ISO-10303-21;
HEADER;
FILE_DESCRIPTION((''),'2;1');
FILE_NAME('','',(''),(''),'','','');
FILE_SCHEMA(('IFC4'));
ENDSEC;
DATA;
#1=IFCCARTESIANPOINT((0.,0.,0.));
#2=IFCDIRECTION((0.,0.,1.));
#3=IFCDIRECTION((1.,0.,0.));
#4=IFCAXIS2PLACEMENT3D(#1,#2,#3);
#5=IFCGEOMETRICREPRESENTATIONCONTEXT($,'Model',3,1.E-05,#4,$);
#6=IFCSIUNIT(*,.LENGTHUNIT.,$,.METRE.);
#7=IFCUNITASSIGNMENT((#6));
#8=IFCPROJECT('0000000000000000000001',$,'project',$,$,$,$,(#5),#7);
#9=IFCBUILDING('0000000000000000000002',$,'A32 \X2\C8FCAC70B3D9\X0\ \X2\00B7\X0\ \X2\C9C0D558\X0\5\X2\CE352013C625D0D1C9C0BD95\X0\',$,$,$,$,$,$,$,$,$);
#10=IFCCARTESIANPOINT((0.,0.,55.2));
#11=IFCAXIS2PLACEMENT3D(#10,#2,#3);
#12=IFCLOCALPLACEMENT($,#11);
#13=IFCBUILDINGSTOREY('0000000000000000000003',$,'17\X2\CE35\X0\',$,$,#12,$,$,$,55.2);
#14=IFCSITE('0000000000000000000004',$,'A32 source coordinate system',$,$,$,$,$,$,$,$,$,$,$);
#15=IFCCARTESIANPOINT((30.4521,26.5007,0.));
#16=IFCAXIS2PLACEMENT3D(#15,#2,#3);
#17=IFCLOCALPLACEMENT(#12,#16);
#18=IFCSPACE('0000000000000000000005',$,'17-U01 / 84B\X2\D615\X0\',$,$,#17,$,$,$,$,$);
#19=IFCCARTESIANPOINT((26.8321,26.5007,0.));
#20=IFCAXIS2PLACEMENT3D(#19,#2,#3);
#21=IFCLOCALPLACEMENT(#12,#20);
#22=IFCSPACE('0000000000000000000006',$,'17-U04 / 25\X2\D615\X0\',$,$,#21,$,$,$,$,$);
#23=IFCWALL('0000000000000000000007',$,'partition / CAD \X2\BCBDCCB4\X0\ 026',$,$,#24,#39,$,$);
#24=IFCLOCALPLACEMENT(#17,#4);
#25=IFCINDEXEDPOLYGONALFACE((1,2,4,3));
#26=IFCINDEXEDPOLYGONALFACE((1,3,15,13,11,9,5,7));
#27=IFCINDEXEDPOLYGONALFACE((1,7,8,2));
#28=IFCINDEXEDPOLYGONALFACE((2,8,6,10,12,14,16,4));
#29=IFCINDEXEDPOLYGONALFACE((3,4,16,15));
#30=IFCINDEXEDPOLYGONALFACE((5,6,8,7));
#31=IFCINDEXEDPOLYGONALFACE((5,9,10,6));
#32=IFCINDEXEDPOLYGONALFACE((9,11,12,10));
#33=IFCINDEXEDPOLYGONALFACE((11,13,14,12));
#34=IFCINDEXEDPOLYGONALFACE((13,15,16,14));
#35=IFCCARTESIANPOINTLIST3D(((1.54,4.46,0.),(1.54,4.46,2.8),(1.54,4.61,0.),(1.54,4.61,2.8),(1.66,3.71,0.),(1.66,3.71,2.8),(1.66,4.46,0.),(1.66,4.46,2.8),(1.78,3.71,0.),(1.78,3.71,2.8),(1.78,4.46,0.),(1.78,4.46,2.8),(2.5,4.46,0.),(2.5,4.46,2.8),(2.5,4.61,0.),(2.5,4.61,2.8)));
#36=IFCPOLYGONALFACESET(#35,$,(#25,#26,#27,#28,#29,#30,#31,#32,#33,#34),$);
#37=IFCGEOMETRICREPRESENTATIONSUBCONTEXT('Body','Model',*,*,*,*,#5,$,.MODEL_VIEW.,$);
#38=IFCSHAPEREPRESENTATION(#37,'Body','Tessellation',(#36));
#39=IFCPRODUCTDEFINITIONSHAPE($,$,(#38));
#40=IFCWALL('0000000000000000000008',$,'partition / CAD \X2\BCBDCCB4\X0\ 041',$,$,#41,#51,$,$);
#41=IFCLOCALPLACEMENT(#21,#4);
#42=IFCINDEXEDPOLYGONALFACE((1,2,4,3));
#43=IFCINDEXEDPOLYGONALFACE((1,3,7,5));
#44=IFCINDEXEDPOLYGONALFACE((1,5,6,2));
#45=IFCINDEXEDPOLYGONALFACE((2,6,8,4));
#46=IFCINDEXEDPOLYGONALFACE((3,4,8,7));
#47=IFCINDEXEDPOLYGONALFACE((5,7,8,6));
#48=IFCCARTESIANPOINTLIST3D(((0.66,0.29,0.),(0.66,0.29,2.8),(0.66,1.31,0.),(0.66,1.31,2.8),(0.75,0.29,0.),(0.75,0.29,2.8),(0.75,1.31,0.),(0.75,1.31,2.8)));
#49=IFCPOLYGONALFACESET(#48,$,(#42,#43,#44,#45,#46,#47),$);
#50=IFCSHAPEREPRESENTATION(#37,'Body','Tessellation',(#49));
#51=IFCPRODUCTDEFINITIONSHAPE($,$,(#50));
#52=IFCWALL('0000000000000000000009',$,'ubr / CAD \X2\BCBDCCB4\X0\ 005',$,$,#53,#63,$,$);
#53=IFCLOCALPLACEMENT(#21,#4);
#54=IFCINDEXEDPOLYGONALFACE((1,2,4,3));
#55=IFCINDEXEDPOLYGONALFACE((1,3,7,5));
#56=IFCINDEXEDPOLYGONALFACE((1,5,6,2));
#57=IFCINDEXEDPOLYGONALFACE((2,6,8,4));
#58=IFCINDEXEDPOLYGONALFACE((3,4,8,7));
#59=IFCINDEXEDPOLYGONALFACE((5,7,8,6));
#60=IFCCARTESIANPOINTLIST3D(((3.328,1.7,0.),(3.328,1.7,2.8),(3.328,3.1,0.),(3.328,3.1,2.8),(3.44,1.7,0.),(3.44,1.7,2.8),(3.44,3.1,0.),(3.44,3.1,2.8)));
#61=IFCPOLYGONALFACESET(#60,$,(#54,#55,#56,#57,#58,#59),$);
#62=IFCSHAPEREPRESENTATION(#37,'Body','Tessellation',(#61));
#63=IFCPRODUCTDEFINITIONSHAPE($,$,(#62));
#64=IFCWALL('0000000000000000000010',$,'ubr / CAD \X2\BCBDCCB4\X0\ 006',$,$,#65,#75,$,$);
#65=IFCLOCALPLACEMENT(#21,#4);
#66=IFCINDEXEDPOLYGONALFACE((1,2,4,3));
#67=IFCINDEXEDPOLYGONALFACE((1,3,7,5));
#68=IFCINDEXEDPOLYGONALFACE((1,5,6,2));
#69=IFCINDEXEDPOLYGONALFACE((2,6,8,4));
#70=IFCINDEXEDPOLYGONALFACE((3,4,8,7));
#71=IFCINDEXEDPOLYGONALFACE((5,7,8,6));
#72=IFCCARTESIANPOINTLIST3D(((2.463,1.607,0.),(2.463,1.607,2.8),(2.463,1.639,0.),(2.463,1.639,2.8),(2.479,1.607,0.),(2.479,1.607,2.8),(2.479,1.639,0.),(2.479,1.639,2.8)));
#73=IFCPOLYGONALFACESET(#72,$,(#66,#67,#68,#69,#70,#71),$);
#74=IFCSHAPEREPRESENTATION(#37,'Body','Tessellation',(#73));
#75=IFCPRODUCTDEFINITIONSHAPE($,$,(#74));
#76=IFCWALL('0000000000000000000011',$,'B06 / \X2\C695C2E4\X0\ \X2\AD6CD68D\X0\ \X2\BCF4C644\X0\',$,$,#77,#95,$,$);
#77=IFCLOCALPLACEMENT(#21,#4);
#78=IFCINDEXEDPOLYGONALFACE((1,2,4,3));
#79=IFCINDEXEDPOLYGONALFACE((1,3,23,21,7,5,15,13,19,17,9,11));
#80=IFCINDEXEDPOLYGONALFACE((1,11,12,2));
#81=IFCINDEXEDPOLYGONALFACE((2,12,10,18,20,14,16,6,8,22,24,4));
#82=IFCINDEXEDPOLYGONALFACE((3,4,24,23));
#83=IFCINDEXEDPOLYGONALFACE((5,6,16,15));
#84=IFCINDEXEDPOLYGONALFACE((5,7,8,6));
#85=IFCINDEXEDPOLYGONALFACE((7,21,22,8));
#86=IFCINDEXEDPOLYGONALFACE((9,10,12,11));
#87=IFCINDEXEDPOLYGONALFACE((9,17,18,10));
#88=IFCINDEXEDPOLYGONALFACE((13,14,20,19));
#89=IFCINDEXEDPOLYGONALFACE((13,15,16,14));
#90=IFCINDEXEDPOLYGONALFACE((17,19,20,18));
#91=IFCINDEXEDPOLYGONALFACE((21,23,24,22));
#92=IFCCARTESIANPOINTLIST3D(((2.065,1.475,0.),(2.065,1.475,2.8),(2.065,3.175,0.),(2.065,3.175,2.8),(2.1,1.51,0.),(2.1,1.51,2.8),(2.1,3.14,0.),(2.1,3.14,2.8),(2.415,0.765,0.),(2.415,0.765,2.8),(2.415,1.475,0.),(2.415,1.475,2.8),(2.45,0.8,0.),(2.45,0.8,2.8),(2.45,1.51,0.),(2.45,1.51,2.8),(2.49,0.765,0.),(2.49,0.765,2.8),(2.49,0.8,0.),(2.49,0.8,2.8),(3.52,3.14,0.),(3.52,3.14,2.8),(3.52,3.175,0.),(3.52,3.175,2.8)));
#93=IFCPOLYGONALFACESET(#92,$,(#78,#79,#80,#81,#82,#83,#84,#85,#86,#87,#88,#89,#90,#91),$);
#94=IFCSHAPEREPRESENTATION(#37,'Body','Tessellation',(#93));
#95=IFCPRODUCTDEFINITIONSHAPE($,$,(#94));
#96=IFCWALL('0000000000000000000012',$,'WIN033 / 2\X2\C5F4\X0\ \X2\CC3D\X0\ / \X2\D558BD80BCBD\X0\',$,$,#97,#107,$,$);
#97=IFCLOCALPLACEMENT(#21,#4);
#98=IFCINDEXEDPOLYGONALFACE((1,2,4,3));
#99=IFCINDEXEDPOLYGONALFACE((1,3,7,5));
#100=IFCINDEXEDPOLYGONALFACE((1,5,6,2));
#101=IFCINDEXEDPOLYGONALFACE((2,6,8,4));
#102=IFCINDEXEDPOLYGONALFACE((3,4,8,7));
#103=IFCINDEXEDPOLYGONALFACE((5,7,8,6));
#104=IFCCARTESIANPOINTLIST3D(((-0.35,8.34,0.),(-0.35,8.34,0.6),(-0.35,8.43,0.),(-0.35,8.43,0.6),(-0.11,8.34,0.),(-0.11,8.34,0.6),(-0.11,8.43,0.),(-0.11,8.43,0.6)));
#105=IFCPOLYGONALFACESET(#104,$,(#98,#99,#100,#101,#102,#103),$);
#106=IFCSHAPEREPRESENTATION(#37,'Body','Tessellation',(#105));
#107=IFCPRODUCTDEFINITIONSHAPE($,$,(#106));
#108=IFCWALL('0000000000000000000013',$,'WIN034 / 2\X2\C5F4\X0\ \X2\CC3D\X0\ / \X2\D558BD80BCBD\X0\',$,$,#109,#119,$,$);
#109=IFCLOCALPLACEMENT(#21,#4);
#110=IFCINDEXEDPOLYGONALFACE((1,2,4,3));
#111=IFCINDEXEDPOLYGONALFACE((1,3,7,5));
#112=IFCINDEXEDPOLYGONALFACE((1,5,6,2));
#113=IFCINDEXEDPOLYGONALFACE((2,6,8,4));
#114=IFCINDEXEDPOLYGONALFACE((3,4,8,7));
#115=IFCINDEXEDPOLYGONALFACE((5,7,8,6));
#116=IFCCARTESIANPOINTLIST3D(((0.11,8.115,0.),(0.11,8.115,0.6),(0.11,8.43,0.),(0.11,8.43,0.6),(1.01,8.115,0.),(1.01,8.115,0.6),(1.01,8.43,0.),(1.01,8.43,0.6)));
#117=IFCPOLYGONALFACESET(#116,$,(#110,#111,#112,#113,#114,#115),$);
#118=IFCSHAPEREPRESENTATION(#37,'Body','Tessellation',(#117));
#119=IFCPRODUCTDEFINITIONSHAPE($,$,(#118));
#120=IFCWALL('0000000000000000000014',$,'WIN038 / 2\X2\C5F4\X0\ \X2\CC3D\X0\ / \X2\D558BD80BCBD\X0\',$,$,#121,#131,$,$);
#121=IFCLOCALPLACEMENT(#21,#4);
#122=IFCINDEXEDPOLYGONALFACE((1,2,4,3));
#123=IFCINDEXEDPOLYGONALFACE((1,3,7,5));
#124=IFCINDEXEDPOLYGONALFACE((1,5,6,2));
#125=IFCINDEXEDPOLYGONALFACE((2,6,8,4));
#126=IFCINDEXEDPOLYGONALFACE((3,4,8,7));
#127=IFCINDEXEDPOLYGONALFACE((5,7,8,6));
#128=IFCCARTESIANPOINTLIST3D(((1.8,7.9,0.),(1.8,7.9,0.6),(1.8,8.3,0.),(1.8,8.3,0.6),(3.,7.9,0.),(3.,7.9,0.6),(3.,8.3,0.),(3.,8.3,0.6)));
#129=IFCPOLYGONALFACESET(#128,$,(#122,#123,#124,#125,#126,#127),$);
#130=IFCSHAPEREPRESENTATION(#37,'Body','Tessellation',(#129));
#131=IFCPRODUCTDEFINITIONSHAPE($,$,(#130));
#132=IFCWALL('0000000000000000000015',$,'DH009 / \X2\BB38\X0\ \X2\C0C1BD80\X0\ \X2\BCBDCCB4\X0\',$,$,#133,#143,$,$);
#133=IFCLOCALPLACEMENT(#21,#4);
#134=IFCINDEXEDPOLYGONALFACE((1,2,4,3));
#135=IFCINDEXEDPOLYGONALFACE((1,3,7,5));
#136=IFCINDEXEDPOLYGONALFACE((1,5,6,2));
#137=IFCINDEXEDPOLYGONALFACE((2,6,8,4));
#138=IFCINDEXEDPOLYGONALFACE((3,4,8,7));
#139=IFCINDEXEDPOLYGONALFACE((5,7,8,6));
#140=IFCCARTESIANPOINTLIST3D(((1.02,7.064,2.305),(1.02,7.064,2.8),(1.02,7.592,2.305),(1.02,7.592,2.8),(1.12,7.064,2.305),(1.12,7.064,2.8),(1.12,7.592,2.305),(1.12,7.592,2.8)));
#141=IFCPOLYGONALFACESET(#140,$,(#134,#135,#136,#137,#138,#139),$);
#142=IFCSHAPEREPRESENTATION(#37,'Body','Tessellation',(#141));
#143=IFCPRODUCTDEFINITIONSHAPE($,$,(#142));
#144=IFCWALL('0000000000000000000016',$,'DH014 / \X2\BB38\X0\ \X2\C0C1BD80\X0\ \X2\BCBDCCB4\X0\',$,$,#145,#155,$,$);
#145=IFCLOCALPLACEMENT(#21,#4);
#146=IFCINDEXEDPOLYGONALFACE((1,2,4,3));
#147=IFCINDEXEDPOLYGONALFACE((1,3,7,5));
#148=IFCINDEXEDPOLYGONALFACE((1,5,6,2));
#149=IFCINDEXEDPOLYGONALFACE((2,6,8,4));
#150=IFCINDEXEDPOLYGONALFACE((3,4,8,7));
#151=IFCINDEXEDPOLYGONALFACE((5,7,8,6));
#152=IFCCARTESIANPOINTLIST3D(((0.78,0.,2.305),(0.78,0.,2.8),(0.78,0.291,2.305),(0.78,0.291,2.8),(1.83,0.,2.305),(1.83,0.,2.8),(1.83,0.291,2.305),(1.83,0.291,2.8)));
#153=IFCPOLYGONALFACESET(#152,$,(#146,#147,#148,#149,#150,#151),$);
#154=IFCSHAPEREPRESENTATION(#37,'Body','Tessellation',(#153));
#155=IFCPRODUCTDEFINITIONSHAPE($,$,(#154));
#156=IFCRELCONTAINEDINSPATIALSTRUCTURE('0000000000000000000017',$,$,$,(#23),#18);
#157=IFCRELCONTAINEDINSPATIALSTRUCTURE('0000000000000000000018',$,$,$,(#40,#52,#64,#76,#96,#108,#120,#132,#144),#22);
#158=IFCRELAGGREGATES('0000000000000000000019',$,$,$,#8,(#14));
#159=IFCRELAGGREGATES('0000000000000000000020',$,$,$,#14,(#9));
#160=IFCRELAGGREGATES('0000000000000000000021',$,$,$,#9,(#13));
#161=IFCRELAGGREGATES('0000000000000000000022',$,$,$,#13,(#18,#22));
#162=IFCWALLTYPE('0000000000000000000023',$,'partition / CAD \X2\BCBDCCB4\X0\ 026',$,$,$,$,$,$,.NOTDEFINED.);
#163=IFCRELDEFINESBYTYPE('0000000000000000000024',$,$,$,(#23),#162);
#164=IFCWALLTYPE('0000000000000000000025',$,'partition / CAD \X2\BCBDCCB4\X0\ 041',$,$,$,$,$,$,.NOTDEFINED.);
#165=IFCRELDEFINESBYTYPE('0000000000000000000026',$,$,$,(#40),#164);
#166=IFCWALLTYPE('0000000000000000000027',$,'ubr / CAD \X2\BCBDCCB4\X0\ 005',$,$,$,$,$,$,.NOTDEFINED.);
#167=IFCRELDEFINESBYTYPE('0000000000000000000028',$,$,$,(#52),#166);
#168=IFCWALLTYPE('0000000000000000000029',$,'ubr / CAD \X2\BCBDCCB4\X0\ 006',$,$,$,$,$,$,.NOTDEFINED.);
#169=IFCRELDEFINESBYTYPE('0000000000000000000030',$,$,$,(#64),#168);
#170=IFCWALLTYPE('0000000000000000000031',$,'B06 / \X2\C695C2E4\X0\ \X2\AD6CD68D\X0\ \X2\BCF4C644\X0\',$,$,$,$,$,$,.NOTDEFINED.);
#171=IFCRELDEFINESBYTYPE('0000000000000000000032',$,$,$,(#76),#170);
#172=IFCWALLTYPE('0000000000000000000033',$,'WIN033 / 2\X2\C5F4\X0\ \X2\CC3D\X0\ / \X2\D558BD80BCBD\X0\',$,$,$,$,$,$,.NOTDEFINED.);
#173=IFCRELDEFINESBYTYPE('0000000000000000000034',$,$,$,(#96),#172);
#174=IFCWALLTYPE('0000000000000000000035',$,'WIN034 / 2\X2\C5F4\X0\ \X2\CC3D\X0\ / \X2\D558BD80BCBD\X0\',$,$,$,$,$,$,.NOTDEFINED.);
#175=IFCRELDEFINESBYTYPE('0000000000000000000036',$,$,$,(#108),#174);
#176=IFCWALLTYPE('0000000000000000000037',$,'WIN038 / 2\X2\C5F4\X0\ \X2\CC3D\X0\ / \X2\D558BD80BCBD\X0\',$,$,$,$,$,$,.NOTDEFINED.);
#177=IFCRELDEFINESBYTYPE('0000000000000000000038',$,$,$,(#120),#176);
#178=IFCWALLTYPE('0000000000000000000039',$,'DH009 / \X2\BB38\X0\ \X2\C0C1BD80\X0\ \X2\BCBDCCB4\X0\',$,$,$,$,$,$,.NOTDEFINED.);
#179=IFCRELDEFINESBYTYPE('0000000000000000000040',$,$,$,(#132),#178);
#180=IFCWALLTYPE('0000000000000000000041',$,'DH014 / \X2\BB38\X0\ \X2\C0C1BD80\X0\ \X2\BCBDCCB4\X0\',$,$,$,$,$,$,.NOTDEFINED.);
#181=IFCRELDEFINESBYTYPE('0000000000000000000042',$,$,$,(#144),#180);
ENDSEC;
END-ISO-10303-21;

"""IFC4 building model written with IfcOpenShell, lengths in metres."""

from ifc_helpers import new_model, si_unit, frame, origin, origin_with_axes, place, context, subcontext, project, spatial, polyline, outline, extrude, source, transform, mapped, type_object, type_shapes, element, save


model = new_model("IFC4")

# Units and contexts
model_context = context("Model", 3, precision=1e-05, world=origin_with_axes())
body_context = subcontext(model_context, "Body", "Model", "MODEL_VIEW")
ifc_project = project(units=[si_unit("LENGTHUNIT", "METRE")], contexts=[model_context])

# Site, building, storey, space
site = spatial("IfcSite", under=ifc_project, Name="A32 source coordinate system")
building = spatial("IfcBuilding", under=site, Name="A32 주거동 · 지하5층–옥탑지붕")
storey_placement = place(None, frame((0.0, 0.0, 55.2), z_axis=(0.0, 0.0, 1.0), x_axis=(1.0, 0.0, 0.0)))
storey = spatial("IfcBuildingStorey", under=building, at=storey_placement, Name="17층", Elevation=55.2)
space_1_placement = place(storey_placement, frame((30.4521, 26.5007, 0.0), z_axis=(0.0, 0.0, 1.0), x_axis=(1.0, 0.0, 0.0)))
space_1 = spatial("IfcSpace", under=storey, at=space_1_placement, Name="17-U01 / 84B형")

# Wall
wall_type_1 = type_object("IfcWallType", Name="partition / CAD 벽체 026", PredefinedType="NOTDEFINED")
shared_shape_1 = source(origin(), body_context, "Body", "SweptSolid", [
    extrude(outline(polyline([(1.54, 4.46), (1.54, 4.61), (2.5, 4.61), (2.5, 4.46), (1.78, 4.46), (1.78, 3.71), (1.66, 3.71), (1.66, 4.46), (1.54, 4.46)])), origin(), (0.0, 0.0, 1.0), 2.8),
])
type_shapes(wall_type_1, [shared_shape_1])
wall_1_placement = place(space_1_placement, origin_with_axes())
element("IfcWall", 1, at=wall_1_placement, inside=space_1, type_object=wall_type_1, Name="partition / CAD 벽체 026", context=body_context, shape_type="MappedRepresentation", body=[
    mapped(shared_shape_1, transform((0.0, 0.0, 0.0), scale=1.0)),
])

# Shared definitions
space_2_placement = place(storey_placement, frame((26.8321, 26.5007, 0.0), z_axis=(0.0, 0.0, 1.0), x_axis=(1.0, 0.0, 0.0)))
space_2 = spatial("IfcSpace", under=storey, at=space_2_placement, Name="17-U04 / 25형")

# Walls
wall_type_2 = type_object("IfcWallType", Name="partition / CAD 벽체 041", PredefinedType="NOTDEFINED")
shared_shape_2 = source(origin(), body_context, "Body", "SweptSolid", [
    extrude(outline(polyline([(0.75, 1.31), (0.75, 0.29), (0.66, 0.29), (0.66, 1.31), (0.75, 1.31)])), origin(), (0.0, 0.0, 1.0), 2.8),
])
type_shapes(wall_type_2, [shared_shape_2])
wall_2_placement = place(space_2_placement, origin_with_axes())
element("IfcWall", 2, at=wall_2_placement, inside=space_2, type_object=wall_type_2, Name="partition / CAD 벽체 041", context=body_context, shape_type="MappedRepresentation", body=[
    mapped(shared_shape_2, transform((0.0, 0.0, 0.0), scale=1.0)),
])
wall_type_3 = type_object("IfcWallType", Name="ubr / CAD 벽체 005", PredefinedType="NOTDEFINED")
shared_shape_3 = source(origin(), body_context, "Body", "SweptSolid", [
    extrude(outline(polyline([(3.44, 3.1), (3.44, 1.7), (3.328, 1.7), (3.328, 3.1), (3.44, 3.1)])), origin(), (0.0, 0.0, 1.0), 2.8),
])
type_shapes(wall_type_3, [shared_shape_3])
wall_3_placement = place(space_2_placement, origin_with_axes())
element("IfcWall", 3, at=wall_3_placement, inside=space_2, type_object=wall_type_3, Name="ubr / CAD 벽체 005", context=body_context, shape_type="MappedRepresentation", body=[
    mapped(shared_shape_3, transform((0.0, 0.0, 0.0), scale=1.0)),
])
wall_type_4 = type_object("IfcWallType", Name="ubr / CAD 벽체 006", PredefinedType="NOTDEFINED")
shared_shape_4 = source(origin(), body_context, "Body", "SweptSolid", [
    extrude(outline(polyline([(2.463, 1.639), (2.479, 1.639), (2.479, 1.607), (2.463, 1.607), (2.463, 1.639)])), origin(), (0.0, 0.0, 1.0), 2.8),
])
type_shapes(wall_type_4, [shared_shape_4])
wall_4_placement = place(space_2_placement, origin_with_axes())
element("IfcWall", 4, at=wall_4_placement, inside=space_2, type_object=wall_type_4, Name="ubr / CAD 벽체 006", context=body_context, shape_type="MappedRepresentation", body=[
    mapped(shared_shape_4, transform((0.0, 0.0, 0.0), scale=1.0)),
])
wall_type_5 = type_object("IfcWallType", Name="B06 / 욕실 구획 보완", PredefinedType="NOTDEFINED")
shared_shape_5 = source(origin(), body_context, "Body", "SweptSolid", [
    extrude(outline(polyline([(3.52, 3.14), (2.1, 3.14), (2.1, 1.51), (2.45, 1.51), (2.45, 0.8), (2.49, 0.8), (2.49, 0.765), (2.415, 0.765), (2.415, 1.475), (2.065, 1.475), (2.065, 3.175), (3.52, 3.175), (3.52, 3.14)])), origin(), (0.0, 0.0, 1.0), 2.8),
])
type_shapes(wall_type_5, [shared_shape_5])
wall_5_placement = place(space_2_placement, origin_with_axes())
element("IfcWall", 5, at=wall_5_placement, inside=space_2, type_object=wall_type_5, Name="B06 / 욕실 구획 보완", context=body_context, shape_type="MappedRepresentation", body=[
    mapped(shared_shape_5, transform((0.0, 0.0, 0.0), scale=1.0)),
])
wall_type_6 = type_object("IfcWallType", Name="WIN033 / 2열 창 / 하부벽", PredefinedType="NOTDEFINED")
shared_shape_6 = source(origin(), body_context, "Body", "SweptSolid", [
    extrude(outline(polyline([(-0.11, 8.43), (-0.11, 8.34), (-0.35, 8.34), (-0.35, 8.43), (-0.11, 8.43)])), origin(), (0.0, 0.0, 1.0), 0.6),
])
type_shapes(wall_type_6, [shared_shape_6])
wall_6_placement = place(space_2_placement, origin_with_axes())
element("IfcWall", 6, at=wall_6_placement, inside=space_2, type_object=wall_type_6, Name="WIN033 / 2열 창 / 하부벽", context=body_context, shape_type="MappedRepresentation", body=[
    mapped(shared_shape_6, transform((0.0, 0.0, 0.0), scale=1.0)),
])
wall_type_7 = type_object("IfcWallType", Name="WIN034 / 2열 창 / 하부벽", PredefinedType="NOTDEFINED")
shared_shape_7 = source(origin(), body_context, "Body", "SweptSolid", [
    extrude(outline(polyline([(0.11, 8.115), (0.11, 8.43), (1.01, 8.43), (1.01, 8.115), (0.11, 8.115)])), origin(), (0.0, 0.0, 1.0), 0.6),
])
type_shapes(wall_type_7, [shared_shape_7])
wall_7_placement = place(space_2_placement, origin_with_axes())
element("IfcWall", 7, at=wall_7_placement, inside=space_2, type_object=wall_type_7, Name="WIN034 / 2열 창 / 하부벽", context=body_context, shape_type="MappedRepresentation", body=[
    mapped(shared_shape_7, transform((0.0, 0.0, 0.0), scale=1.0)),
])
wall_type_8 = type_object("IfcWallType", Name="WIN038 / 2열 창 / 하부벽", PredefinedType="NOTDEFINED")
shared_shape_8 = source(origin(), body_context, "Body", "SweptSolid", [
    extrude(outline(polyline([(1.8, 7.9), (1.8, 8.3), (3.0, 8.3), (3.0, 7.9), (1.8, 7.9)])), origin(), (0.0, 0.0, 1.0), 0.6),
])
type_shapes(wall_type_8, [shared_shape_8])
wall_8_placement = place(space_2_placement, origin_with_axes())
element("IfcWall", 8, at=wall_8_placement, inside=space_2, type_object=wall_type_8, Name="WIN038 / 2열 창 / 하부벽", context=body_context, shape_type="MappedRepresentation", body=[
    mapped(shared_shape_8, transform((0.0, 0.0, 0.0), scale=1.0)),
])
wall_type_9 = type_object("IfcWallType", Name="DH009 / 문 상부 벽체", PredefinedType="NOTDEFINED")
shared_shape_9 = source(origin(), body_context, "Body", "SweptSolid", [
    extrude(outline(polyline([(1.02, 7.064), (1.02, 7.592), (1.12, 7.592), (1.12, 7.064), (1.02, 7.064)])), frame((0.0, 0.0, 2.305)), (0.0, 0.0, 1.0), 0.495),
])
type_shapes(wall_type_9, [shared_shape_9])
wall_9_placement = place(space_2_placement, origin_with_axes())
element("IfcWall", 9, at=wall_9_placement, inside=space_2, type_object=wall_type_9, Name="DH009 / 문 상부 벽체", context=body_context, shape_type="MappedRepresentation", body=[
    mapped(shared_shape_9, transform((0.0, 0.0, 0.0), scale=1.0)),
])
wall_type_10 = type_object("IfcWallType", Name="DH014 / 문 상부 벽체", PredefinedType="NOTDEFINED")
shared_shape_10 = source(origin(), body_context, "Body", "SweptSolid", [
    extrude(outline(polyline([(0.78, 0.291), (1.83, 0.291), (1.83, 0.0), (0.78, 0.0), (0.78, 0.291)])), frame((0.0, 0.0, 2.305)), (0.0, 0.0, 1.0), 0.495),
])
type_shapes(wall_type_10, [shared_shape_10])
wall_10_placement = place(space_2_placement, origin_with_axes())
element("IfcWall", 10, at=wall_10_placement, inside=space_2, type_object=wall_type_10, Name="DH014 / 문 상부 벽체", context=body_context, shape_type="MappedRepresentation", body=[
    mapped(shared_shape_10, transform((0.0, 0.0, 0.0), scale=1.0)),
])

save(model, "model.ifc")
